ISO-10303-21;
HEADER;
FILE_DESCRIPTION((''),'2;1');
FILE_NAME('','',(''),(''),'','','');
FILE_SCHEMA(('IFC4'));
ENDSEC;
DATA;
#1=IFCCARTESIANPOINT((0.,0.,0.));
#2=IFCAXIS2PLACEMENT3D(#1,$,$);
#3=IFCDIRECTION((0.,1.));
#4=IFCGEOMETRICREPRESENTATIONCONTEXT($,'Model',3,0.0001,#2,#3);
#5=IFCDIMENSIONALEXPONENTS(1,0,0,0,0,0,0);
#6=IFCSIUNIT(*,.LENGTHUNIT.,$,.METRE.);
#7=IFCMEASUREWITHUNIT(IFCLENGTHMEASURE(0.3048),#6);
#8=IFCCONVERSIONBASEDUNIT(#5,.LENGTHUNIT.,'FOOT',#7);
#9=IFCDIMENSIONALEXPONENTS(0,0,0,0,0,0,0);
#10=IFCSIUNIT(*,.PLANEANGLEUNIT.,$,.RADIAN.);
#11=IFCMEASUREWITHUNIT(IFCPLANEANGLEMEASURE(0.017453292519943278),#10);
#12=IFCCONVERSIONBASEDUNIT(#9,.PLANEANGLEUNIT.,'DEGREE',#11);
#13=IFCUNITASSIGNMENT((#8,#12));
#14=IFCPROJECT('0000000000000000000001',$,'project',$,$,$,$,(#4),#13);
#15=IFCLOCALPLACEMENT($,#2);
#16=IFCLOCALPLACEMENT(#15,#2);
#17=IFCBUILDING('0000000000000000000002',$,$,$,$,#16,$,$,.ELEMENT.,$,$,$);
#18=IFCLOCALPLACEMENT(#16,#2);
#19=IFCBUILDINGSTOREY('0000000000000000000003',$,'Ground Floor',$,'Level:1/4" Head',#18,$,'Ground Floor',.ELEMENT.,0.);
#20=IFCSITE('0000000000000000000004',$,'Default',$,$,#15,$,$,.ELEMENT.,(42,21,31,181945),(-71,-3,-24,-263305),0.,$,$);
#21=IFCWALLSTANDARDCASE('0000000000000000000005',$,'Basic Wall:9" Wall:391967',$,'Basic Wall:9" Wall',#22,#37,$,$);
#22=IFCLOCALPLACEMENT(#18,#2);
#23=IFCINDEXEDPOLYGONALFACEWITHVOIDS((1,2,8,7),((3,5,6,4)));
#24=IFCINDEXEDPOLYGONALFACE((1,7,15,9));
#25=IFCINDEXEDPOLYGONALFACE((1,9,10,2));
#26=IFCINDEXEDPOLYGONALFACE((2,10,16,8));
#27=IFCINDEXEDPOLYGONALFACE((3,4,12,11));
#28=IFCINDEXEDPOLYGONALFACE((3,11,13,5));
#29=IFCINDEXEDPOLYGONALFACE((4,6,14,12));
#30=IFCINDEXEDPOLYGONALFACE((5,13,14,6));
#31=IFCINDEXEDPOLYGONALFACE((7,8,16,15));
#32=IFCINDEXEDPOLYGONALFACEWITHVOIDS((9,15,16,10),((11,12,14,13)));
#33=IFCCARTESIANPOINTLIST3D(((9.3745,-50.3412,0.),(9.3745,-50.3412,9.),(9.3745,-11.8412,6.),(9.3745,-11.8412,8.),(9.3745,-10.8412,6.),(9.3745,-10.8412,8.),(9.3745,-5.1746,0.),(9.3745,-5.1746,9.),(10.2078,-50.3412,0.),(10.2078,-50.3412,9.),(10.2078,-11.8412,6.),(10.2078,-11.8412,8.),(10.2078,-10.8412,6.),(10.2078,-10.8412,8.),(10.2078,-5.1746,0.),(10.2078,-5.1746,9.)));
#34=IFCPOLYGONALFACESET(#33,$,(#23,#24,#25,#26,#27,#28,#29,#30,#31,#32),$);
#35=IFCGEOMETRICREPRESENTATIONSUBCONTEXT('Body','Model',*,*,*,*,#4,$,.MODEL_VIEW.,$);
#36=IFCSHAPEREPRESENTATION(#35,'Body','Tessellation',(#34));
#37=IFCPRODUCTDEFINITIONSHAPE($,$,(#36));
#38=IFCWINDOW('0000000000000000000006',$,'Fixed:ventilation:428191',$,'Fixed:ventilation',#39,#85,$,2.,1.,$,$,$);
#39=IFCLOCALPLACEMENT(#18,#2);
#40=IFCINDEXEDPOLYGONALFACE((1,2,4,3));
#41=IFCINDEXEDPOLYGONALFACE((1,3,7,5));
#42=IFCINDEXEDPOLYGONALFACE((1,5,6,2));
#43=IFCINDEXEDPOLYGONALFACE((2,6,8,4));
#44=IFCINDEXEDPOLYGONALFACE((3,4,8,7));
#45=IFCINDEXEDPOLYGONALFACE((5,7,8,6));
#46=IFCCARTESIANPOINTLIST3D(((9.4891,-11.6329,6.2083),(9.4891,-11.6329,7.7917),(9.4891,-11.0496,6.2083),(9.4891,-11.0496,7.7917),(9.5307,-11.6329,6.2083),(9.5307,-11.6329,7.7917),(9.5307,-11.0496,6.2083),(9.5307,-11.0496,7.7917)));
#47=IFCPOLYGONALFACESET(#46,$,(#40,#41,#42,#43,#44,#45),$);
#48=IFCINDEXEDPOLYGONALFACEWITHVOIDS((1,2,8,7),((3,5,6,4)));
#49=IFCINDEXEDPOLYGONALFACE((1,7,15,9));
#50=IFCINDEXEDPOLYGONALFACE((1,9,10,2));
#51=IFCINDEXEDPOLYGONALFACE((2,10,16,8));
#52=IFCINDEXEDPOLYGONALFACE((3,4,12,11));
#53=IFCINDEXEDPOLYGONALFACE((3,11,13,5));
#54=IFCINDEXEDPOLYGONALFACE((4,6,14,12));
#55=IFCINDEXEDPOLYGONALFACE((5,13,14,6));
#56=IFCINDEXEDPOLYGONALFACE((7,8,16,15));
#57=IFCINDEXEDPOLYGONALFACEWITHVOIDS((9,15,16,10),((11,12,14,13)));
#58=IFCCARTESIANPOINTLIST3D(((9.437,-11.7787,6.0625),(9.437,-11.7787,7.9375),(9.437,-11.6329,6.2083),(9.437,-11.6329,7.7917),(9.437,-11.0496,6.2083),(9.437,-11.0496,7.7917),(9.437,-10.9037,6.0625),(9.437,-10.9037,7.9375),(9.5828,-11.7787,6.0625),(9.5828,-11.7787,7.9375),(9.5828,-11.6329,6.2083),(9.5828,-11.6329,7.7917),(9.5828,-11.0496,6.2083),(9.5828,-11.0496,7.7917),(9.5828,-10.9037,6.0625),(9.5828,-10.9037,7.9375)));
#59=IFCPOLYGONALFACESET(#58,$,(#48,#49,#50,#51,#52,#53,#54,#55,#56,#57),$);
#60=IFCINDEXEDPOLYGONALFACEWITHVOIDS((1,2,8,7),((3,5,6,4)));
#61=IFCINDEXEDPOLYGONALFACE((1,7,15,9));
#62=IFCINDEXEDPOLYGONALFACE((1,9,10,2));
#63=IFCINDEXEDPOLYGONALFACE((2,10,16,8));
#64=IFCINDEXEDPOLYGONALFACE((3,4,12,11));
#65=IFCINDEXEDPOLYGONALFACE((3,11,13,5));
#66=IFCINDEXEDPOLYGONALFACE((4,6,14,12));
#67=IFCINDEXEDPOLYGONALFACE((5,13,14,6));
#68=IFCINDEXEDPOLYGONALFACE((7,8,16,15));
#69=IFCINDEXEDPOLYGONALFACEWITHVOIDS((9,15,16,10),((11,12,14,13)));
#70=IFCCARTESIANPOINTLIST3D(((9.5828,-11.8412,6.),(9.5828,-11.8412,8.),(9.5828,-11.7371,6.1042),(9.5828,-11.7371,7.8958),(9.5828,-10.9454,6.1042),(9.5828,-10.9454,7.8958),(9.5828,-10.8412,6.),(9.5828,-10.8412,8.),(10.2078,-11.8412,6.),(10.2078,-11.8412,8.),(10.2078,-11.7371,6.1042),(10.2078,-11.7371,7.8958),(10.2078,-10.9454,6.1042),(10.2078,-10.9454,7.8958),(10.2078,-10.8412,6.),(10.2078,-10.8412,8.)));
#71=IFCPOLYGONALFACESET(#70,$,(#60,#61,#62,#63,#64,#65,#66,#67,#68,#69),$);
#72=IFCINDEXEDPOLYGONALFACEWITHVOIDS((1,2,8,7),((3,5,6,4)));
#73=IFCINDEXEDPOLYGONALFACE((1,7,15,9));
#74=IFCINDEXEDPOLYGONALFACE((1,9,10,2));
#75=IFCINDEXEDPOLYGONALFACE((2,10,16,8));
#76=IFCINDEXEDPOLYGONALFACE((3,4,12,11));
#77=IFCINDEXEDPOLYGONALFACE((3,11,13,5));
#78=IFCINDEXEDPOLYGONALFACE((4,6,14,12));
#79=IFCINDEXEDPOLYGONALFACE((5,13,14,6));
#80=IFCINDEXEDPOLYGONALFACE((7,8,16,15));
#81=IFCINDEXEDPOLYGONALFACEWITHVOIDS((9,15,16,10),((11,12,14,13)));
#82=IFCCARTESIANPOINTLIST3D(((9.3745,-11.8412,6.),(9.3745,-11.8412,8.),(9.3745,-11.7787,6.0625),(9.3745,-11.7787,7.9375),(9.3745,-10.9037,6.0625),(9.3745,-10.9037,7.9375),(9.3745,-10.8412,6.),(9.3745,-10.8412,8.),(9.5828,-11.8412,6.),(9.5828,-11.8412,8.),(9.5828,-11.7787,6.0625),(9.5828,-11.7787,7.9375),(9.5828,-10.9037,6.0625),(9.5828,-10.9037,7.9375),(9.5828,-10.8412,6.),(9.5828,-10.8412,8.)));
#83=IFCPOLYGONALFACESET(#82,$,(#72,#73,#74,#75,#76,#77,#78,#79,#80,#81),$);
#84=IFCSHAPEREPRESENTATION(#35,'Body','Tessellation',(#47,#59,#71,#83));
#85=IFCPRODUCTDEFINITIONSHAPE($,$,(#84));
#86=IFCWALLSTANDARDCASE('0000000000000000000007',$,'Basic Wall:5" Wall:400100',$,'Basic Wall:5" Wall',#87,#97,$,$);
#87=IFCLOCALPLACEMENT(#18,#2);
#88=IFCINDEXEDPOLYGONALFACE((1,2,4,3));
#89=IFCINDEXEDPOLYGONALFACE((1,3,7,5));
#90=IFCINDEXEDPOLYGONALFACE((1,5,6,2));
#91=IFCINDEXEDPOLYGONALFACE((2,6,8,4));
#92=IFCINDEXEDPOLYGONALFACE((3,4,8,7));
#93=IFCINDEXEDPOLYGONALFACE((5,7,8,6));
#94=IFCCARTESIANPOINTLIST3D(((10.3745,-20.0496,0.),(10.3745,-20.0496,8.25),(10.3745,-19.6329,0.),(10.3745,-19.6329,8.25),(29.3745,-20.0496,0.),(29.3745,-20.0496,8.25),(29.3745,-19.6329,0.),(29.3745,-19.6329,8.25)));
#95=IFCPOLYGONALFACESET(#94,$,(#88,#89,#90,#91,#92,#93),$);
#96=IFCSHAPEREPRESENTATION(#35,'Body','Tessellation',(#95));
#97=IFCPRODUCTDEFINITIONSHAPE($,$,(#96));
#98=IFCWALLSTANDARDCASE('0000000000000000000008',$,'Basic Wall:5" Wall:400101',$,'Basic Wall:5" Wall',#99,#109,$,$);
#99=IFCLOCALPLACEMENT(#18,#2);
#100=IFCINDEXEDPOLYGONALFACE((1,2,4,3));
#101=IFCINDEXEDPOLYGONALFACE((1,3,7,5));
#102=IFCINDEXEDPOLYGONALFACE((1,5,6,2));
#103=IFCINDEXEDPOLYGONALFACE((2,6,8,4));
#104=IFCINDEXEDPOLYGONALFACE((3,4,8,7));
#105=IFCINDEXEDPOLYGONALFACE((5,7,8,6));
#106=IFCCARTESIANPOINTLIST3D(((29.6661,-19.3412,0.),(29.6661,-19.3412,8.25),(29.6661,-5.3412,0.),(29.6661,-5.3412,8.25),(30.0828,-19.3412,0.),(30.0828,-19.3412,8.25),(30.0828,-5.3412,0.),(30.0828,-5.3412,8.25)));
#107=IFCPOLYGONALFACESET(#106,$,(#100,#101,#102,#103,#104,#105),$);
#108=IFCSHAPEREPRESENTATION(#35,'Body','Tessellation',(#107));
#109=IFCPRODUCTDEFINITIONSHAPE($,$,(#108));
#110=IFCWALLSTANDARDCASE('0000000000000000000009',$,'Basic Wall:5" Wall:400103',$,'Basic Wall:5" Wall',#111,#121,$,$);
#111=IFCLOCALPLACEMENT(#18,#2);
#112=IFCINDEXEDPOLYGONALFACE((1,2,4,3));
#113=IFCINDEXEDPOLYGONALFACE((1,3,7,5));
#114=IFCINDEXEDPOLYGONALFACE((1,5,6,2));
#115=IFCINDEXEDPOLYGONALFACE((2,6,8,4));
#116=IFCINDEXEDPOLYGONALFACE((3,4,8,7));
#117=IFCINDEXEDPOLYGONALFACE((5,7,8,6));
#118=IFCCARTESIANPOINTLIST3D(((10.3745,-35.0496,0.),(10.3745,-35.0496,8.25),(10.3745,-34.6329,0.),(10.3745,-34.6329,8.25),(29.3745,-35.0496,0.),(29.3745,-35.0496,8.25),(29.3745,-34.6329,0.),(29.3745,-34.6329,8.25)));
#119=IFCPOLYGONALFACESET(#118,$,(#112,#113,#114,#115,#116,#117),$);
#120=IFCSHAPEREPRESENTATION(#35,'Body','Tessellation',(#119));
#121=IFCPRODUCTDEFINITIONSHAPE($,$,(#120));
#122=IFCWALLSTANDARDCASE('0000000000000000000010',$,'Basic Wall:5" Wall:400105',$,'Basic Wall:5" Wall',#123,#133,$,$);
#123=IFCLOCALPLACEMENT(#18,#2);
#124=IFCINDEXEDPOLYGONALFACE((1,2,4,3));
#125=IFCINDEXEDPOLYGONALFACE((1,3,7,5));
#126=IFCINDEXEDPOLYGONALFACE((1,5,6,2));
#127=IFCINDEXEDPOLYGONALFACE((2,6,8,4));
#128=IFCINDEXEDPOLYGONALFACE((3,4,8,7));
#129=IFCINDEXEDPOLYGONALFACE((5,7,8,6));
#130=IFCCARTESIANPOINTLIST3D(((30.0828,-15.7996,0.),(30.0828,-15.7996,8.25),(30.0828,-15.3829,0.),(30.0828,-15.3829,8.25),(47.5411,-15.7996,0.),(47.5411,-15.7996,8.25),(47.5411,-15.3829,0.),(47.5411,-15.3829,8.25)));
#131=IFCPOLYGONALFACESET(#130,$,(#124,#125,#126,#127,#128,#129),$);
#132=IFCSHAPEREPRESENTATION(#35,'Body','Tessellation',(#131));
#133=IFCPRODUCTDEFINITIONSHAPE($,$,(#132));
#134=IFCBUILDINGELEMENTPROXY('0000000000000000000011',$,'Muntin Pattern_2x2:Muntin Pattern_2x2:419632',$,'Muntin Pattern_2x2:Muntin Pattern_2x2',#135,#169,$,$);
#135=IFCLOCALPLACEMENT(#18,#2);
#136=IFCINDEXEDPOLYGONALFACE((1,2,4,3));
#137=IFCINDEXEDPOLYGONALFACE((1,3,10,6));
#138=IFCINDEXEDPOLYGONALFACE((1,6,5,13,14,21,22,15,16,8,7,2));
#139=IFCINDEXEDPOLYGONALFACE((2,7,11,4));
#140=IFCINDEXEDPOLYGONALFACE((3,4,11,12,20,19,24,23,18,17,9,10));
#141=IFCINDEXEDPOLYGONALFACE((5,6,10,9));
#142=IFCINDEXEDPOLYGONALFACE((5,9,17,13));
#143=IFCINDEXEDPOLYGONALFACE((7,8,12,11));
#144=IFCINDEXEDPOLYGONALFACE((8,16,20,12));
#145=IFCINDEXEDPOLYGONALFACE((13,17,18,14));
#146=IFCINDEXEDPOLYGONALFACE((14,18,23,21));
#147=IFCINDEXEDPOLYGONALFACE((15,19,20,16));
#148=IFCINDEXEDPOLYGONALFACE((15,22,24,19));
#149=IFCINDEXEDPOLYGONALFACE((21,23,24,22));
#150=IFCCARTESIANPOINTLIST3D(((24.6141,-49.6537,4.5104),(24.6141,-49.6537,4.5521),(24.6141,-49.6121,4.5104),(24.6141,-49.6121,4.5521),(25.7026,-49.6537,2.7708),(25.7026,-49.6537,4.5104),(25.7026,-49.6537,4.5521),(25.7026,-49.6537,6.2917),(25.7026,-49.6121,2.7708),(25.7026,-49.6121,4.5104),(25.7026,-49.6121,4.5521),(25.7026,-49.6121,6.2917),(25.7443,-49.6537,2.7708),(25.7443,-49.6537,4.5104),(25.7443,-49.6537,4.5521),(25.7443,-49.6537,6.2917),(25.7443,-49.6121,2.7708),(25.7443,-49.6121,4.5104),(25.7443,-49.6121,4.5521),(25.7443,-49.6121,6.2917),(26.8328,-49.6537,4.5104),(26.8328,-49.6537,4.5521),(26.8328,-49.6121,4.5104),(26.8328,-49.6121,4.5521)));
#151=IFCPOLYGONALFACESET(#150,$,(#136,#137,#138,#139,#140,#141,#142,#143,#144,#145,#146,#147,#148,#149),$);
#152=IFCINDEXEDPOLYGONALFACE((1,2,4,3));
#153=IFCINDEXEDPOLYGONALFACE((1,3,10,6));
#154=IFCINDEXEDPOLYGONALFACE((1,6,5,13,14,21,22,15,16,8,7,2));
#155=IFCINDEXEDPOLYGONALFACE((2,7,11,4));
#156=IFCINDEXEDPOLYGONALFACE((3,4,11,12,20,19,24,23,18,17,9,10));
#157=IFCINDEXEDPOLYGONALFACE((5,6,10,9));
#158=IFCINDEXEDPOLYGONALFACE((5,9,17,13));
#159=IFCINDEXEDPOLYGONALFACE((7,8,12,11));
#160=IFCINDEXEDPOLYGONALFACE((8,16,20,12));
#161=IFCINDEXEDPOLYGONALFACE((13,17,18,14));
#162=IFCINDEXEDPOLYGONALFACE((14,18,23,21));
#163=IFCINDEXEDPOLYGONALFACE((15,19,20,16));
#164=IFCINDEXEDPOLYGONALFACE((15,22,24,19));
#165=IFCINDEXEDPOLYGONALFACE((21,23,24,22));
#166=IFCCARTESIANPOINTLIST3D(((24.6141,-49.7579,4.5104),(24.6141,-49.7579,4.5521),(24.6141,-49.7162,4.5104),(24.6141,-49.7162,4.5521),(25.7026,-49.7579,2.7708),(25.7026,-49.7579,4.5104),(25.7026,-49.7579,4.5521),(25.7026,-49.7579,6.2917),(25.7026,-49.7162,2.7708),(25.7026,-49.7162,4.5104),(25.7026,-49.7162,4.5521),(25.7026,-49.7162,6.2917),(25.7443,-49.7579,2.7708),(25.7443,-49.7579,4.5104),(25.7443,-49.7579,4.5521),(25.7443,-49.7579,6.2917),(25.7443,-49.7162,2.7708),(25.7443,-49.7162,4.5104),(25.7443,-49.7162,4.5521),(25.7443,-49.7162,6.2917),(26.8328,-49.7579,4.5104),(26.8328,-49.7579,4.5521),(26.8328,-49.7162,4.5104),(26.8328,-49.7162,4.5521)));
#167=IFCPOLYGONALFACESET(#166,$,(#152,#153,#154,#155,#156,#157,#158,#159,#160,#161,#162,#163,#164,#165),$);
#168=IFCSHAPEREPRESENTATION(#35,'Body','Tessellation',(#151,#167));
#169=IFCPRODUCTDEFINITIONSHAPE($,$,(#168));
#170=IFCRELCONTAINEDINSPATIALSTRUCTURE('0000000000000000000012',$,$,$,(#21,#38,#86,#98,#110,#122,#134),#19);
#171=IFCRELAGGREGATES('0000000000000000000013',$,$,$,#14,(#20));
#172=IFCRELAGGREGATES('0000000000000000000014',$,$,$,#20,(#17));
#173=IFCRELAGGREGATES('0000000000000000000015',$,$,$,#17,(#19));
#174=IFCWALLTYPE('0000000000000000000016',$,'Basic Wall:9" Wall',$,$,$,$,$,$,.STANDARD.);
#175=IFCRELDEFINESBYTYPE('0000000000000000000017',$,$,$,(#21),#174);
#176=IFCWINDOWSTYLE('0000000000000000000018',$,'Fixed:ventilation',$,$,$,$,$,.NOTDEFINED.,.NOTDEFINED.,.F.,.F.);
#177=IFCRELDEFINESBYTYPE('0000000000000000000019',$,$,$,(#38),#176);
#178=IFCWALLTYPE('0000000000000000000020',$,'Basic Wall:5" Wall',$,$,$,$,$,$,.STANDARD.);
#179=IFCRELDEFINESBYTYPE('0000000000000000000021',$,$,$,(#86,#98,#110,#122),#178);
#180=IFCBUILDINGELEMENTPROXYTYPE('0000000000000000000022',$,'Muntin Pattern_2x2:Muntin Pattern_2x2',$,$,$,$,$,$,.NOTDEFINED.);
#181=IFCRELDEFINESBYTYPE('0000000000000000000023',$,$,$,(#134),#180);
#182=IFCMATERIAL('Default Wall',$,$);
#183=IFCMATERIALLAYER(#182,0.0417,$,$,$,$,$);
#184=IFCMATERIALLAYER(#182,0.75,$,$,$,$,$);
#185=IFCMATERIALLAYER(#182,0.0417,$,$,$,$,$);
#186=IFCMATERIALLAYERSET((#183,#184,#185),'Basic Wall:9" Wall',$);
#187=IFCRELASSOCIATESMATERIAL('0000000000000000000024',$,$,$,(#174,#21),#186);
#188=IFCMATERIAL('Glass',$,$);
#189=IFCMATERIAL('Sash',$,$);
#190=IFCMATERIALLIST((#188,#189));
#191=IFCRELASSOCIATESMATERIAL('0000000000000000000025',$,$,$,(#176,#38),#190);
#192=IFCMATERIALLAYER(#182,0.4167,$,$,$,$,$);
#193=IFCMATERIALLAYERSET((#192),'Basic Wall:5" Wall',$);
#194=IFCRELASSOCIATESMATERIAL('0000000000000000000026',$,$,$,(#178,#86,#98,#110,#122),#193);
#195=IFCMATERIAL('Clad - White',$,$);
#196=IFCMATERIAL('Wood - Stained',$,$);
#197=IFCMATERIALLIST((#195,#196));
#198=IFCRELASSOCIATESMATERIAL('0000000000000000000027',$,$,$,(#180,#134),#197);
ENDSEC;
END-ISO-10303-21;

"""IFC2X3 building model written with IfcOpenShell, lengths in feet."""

from ifc_helpers import new_model, entity, si_unit, converted_unit, direction, frame, frame_2d, origin, origin_2d_with_axis, place, context, subcontext, project, spatial, polyline, rectangle, outline, extrude, clip, bounded_halfspace, source, transform, mapped, material, material_list, layer, layer_set, layer_usage, type_object, type_shapes, element, fill, save


model = new_model("IFC2X3")

# Units and contexts
model_context = context("Model", 3, precision=0.0001, world=origin(), true_north=direction((0.0, 1.0)))
body_context = subcontext(model_context, "Body", "Model", "MODEL_VIEW")
ifc_project = project(units=[converted_unit("LENGTHUNIT", "FOOT", entity("IfcLengthMeasure", 0.3048), si_unit("LENGTHUNIT", "METRE"), dimensions=[1, 0, 0, 0, 0, 0, 0]), converted_unit("PLANEANGLEUNIT", "DEGREE", entity("IfcPlaneAngleMeasure", 0.017453292519943278), si_unit("PLANEANGLEUNIT", "RADIAN"), dimensions=[0, 0, 0, 0, 0, 0, 0])], contexts=[model_context])

# Site, building, storey
site_placement = place(None, origin())
site = spatial("IfcSite", under=ifc_project, at=site_placement, Name="Default", CompositionType="ELEMENT", RefLatitude=(42, 21, 31, 181945), RefLongitude=(-71, -3, -24, -263305), RefElevation=0.0)
building_placement = place(site_placement, origin())
building = spatial("IfcBuilding", under=site, at=building_placement, CompositionType="ELEMENT")
storey_placement = place(building_placement, origin())
storey = spatial("IfcBuildingStorey", under=building, at=storey_placement, Name="Ground Floor", ObjectType="Level:1/4\" Head", LongName="Ground Floor", CompositionType="ELEMENT", Elevation=0.0)

# Shared definitions
ifc_material_1 = material(Name="Default Wall")
ifc_layer_1 = layer(ifc_material_1, 0.0417)
ifc_layer_2 = layer(ifc_material_1, 0.75)
ifc_layer_3 = layer(ifc_material_1, 0.0417)
ifc_layer_set_1 = layer_set([ifc_layer_1, ifc_layer_2, ifc_layer_3], Name="Basic Wall:9\" Wall")
ifc_layer_usage_1 = layer_usage(ifc_layer_set_1, "AXIS2", "NEGATIVE", 0.4167)
wall_type_1 = type_object("IfcWallType", Name="Basic Wall:9\" Wall", PredefinedType="STANDARD", material=ifc_layer_set_1)

# Wall, opening, window
wall_1_placement = place(storey_placement, frame((9.7911, -50.3412, 0.0), z_axis=(0.0, 0.0, 1.0), x_axis=(0.0, 1.0, 0.0)))
wall_1 = element("IfcWallStandardCase", 1, at=wall_1_placement, inside=storey, type_object=wall_type_1, material=ifc_layer_usage_1, Name="Basic Wall:9\" Wall:391967", ObjectType="Basic Wall:9\" Wall", context=body_context, shape_type="Clipping", body=[
    clip(extrude(rectangle(XDim=45.1667, YDim=0.8333, at=frame_2d((22.5833, 0.0), x_axis=(-1.0, 0.0))), origin(), (0.0, 0.0, 1.0), 9.0), bounded_halfspace(frame((0.0, -0.4167, 9.0), z_axis=(0.0, 0.0, -1.0), x_axis=(-1.0, 0.0, 0.0)), True, frame((0.0, -0.4167, 9.0)), polyline([(0.0, 0.0), (0.8333, 0.0), (45.1667, 0.0), (45.1667, 0.8333), (0.0, 0.8333), (0.0, 0.0)]))),
])
opening_1_placement = place(wall_1_placement, frame((38.5, -0.4167, 6.0)))
opening_1 = element("IfcOpeningElement", 2, at=opening_1_placement, cuts=wall_1, ObjectType="Opening", context=body_context, shape_type="SweptSolid", body=[
    extrude(rectangle(XDim=2.0, YDim=1.0, at=frame_2d((1.0, 0.5), x_axis=(-1.0, 0.0))), frame((0.0, 0.0, 0.0), z_axis=(0.0, 1.0, 0.0), x_axis=(0.0, 0.0, 1.0)), (0.0, 0.0, 1.0), 0.8333),
])
ifc_material_2 = material(Name="Glass")
ifc_material_3 = material(Name="Sash")
ifc_material_list_1 = material_list([ifc_material_2, ifc_material_3])
window_style = type_object("IfcWindowStyle", Name="Fixed:ventilation", ConstructionType="NOTDEFINED", OperationType="NOTDEFINED", ParameterTakesPrecedence=False, Sizeable=False, material=ifc_material_list_1)
shared_shape_1 = source(origin(), body_context, "Body", "SweptSolid", [
    extrude(rectangle(XDim=0.0417, YDim=0.5833, at=origin_2d_with_axis()), frame((0.5, 0.6979, 0.2083), z_axis=(0.0, 0.0, 1.0), x_axis=(0.0, 1.0, 0.0)), (0.0, 0.0, 1.0), 1.5833),
    extrude(outline(polyline([(-0.4375, -0.9375), (0.4375, -0.9375), (0.4375, 0.9375), (-0.4375, 0.9375), (-0.4375, -0.9375)]), holes=[polyline([(-0.2917, -0.7917), (-0.2917, 0.7917), (0.2917, 0.7917), (0.2917, -0.7917), (-0.2917, -0.7917)])]), frame((0.5, 0.625, 1.0), z_axis=(0.0, 1.0, 0.0), x_axis=(1.0, 0.0, 0.0)), (0.0, 0.0, 1.0), 0.1458),
    extrude(outline(polyline([(-0.5, -1.0), (0.5, -1.0), (0.5, 1.0), (-0.5, 1.0), (-0.5, -1.0)]), holes=[polyline([(-0.3958, -0.8958), (-0.3958, 0.8958), (0.3958, 0.8958), (0.3958, -0.8958), (-0.3958, -0.8958)])]), frame((0.5, 0.0, 1.0), z_axis=(0.0, 1.0, 0.0), x_axis=(1.0, 0.0, 0.0)), (0.0, 0.0, 1.0), 0.625),
    extrude(outline(polyline([(-1.0, -0.5), (1.0, -0.5), (1.0, 0.5), (-1.0, 0.5), (-1.0, -0.5)]), holes=[polyline([(-0.9375, -0.4375), (-0.9375, 0.4375), (0.9375, 0.4375), (0.9375, -0.4375), (-0.9375, -0.4375)])]), frame((0.5, 0.625, 1.0), z_axis=(0.0, 1.0, 0.0), x_axis=(0.0, 0.0, -1.0)), (0.0, 0.0, 1.0), 0.2083),
])
type_shapes(window_style, [shared_shape_1])
window_placement = place(opening_1_placement, origin())
window = element("IfcWindow", 3, at=window_placement, inside=storey, type_object=window_style, material=ifc_material_list_1, Name="Fixed:ventilation:428191", ObjectType="Fixed:ventilation", OverallHeight=2.0, OverallWidth=1.0, context=body_context, shape_type="MappedRepresentation", body=[
    mapped(shared_shape_1, transform((0.0, 0.0, 0.0), scale=1.0)),
])
fill(opening_1, window)

# Walls
ifc_layer_4 = layer(ifc_material_1, 0.4167)
ifc_layer_set_2 = layer_set([ifc_layer_4], Name="Basic Wall:5\" Wall")
ifc_layer_usage_2 = layer_usage(ifc_layer_set_2, "AXIS2", "NEGATIVE", 0.2083)
wall_type_2 = type_object("IfcWallType", Name="Basic Wall:5\" Wall", PredefinedType="STANDARD", material=ifc_layer_set_2)
wall_2_placement = place(storey_placement, frame((10.3745, -19.8412, 0.0)))
element("IfcWallStandardCase", 4, at=wall_2_placement, inside=storey, type_object=wall_type_2, material=ifc_layer_usage_2, Name="Basic Wall:5\" Wall:400100", ObjectType="Basic Wall:5\" Wall", context=body_context, shape_type="SweptSolid", body=[
    extrude(rectangle(XDim=19.0, YDim=0.4167, at=frame_2d((9.5, 0.0), x_axis=(-1.0, 0.0))), origin(), (0.0, 0.0, 1.0), 8.25),
])
wall_3_placement = place(storey_placement, frame((29.8745, -19.3412, 0.0), z_axis=(0.0, 0.0, 1.0), x_axis=(0.0, 1.0, 0.0)))
element("IfcWallStandardCase", 5, at=wall_3_placement, inside=storey, type_object=wall_type_2, material=ifc_layer_usage_2, Name="Basic Wall:5\" Wall:400101", ObjectType="Basic Wall:5\" Wall", context=body_context, shape_type="SweptSolid", body=[
    extrude(rectangle(XDim=14.0, YDim=0.4167, at=frame_2d((7.0, 0.0), x_axis=(-1.0, 0.0))), origin(), (0.0, 0.0, 1.0), 8.25),
])

# Wall
wall_4_placement = place(storey_placement, frame((29.3745, -34.8412, 0.0), z_axis=(0.0, 0.0, 1.0), x_axis=(-1.0, 0.0, 0.0)))
element("IfcWallStandardCase", 6, at=wall_4_placement, inside=storey, type_object=wall_type_2, material=ifc_layer_usage_2, Name="Basic Wall:5\" Wall:400103", ObjectType="Basic Wall:5\" Wall", context=body_context, shape_type="SweptSolid", body=[
    extrude(rectangle(XDim=19.0, YDim=0.4167, at=frame_2d((9.5, 0.0), x_axis=(-1.0, 0.0))), origin(), (0.0, 0.0, 1.0), 8.25),
])

# Wall
wall_5_placement = place(storey_placement, frame((30.0828, -15.5912, 0.0)))
element("IfcWallStandardCase", 7, at=wall_5_placement, inside=storey, type_object=wall_type_2, material=ifc_layer_usage_2, Name="Basic Wall:5\" Wall:400105", ObjectType="Basic Wall:5\" Wall", context=body_context, shape_type="SweptSolid", body=[
    extrude(rectangle(XDim=17.4583, YDim=0.4167, at=frame_2d((8.7292, 0.0), x_axis=(-1.0, 0.0))), origin(), (0.0, 0.0, 1.0), 8.25),
])

# Building element proxy
ifc_material_4 = material(Name="Clad - White")
ifc_material_5 = material(Name="Wood - Stained")
ifc_material_list_2 = material_list([ifc_material_4, ifc_material_5])
building_element_proxy_type_1 = type_object("IfcBuildingElementProxyType", Name="Muntin Pattern_2x2:Muntin Pattern_2x2", PredefinedType="NOTDEFINED", material=ifc_material_list_2)
shared_shape_2 = source(origin(), body_context, "Body", "SweptSolid", [
    extrude(outline(polyline([(0.0208, -0.0208), (1.7604, -0.0208), (1.7604, 0.0208), (0.0208, 0.0208), (0.0208, 1.1094), (-0.0208, 1.1094), (-0.0208, 0.0208), (-1.7604, 0.0208), (-1.7604, -0.0208), (-0.0208, -0.0208), (-0.0208, -1.1094), (0.0208, -1.1094), (0.0208, -0.0208)])), frame((0.0, 0.0313, 1.7604), z_axis=(0.0, 1.0, 0.0), x_axis=(0.0, 0.0, 1.0)), (0.0, 0.0, 1.0), 0.0417),
    extrude(outline(polyline([(0.0208, -0.0208), (1.7604, -0.0208), (1.7604, 0.0208), (0.0208, 0.0208), (0.0208, 1.1094), (-0.0208, 1.1094), (-0.0208, 0.0208), (-1.7604, 0.0208), (-1.7604, -0.0208), (-0.0208, -0.0208), (-0.0208, -1.1094), (0.0208, -1.1094), (0.0208, -0.0208)])), frame((0.0, -0.0729, 1.7604), z_axis=(0.0, 1.0, 0.0), x_axis=(0.0, 0.0, 1.0)), (0.0, 0.0, 1.0), 0.0417),
])
type_shapes(building_element_proxy_type_1, [shared_shape_2])
for number, where, name in (
    (8, (25.7234, -49.685, 2.7708), "Muntin Pattern_2x2:Muntin Pattern_2x2:419632"),
):
    element("IfcBuildingElementProxy", number, at=place(storey_placement, frame(where)), inside=storey, type_object=building_element_proxy_type_1, material=ifc_material_list_2, Name=name, ObjectType="Muntin Pattern_2x2:Muntin Pattern_2x2", context=body_context, shape_type="MappedRepresentation", body=[
        mapped(shared_shape_2, transform((0.0, 0.0, 0.0), scale=1.0)),
    ])

save(model, "model.ifc")
